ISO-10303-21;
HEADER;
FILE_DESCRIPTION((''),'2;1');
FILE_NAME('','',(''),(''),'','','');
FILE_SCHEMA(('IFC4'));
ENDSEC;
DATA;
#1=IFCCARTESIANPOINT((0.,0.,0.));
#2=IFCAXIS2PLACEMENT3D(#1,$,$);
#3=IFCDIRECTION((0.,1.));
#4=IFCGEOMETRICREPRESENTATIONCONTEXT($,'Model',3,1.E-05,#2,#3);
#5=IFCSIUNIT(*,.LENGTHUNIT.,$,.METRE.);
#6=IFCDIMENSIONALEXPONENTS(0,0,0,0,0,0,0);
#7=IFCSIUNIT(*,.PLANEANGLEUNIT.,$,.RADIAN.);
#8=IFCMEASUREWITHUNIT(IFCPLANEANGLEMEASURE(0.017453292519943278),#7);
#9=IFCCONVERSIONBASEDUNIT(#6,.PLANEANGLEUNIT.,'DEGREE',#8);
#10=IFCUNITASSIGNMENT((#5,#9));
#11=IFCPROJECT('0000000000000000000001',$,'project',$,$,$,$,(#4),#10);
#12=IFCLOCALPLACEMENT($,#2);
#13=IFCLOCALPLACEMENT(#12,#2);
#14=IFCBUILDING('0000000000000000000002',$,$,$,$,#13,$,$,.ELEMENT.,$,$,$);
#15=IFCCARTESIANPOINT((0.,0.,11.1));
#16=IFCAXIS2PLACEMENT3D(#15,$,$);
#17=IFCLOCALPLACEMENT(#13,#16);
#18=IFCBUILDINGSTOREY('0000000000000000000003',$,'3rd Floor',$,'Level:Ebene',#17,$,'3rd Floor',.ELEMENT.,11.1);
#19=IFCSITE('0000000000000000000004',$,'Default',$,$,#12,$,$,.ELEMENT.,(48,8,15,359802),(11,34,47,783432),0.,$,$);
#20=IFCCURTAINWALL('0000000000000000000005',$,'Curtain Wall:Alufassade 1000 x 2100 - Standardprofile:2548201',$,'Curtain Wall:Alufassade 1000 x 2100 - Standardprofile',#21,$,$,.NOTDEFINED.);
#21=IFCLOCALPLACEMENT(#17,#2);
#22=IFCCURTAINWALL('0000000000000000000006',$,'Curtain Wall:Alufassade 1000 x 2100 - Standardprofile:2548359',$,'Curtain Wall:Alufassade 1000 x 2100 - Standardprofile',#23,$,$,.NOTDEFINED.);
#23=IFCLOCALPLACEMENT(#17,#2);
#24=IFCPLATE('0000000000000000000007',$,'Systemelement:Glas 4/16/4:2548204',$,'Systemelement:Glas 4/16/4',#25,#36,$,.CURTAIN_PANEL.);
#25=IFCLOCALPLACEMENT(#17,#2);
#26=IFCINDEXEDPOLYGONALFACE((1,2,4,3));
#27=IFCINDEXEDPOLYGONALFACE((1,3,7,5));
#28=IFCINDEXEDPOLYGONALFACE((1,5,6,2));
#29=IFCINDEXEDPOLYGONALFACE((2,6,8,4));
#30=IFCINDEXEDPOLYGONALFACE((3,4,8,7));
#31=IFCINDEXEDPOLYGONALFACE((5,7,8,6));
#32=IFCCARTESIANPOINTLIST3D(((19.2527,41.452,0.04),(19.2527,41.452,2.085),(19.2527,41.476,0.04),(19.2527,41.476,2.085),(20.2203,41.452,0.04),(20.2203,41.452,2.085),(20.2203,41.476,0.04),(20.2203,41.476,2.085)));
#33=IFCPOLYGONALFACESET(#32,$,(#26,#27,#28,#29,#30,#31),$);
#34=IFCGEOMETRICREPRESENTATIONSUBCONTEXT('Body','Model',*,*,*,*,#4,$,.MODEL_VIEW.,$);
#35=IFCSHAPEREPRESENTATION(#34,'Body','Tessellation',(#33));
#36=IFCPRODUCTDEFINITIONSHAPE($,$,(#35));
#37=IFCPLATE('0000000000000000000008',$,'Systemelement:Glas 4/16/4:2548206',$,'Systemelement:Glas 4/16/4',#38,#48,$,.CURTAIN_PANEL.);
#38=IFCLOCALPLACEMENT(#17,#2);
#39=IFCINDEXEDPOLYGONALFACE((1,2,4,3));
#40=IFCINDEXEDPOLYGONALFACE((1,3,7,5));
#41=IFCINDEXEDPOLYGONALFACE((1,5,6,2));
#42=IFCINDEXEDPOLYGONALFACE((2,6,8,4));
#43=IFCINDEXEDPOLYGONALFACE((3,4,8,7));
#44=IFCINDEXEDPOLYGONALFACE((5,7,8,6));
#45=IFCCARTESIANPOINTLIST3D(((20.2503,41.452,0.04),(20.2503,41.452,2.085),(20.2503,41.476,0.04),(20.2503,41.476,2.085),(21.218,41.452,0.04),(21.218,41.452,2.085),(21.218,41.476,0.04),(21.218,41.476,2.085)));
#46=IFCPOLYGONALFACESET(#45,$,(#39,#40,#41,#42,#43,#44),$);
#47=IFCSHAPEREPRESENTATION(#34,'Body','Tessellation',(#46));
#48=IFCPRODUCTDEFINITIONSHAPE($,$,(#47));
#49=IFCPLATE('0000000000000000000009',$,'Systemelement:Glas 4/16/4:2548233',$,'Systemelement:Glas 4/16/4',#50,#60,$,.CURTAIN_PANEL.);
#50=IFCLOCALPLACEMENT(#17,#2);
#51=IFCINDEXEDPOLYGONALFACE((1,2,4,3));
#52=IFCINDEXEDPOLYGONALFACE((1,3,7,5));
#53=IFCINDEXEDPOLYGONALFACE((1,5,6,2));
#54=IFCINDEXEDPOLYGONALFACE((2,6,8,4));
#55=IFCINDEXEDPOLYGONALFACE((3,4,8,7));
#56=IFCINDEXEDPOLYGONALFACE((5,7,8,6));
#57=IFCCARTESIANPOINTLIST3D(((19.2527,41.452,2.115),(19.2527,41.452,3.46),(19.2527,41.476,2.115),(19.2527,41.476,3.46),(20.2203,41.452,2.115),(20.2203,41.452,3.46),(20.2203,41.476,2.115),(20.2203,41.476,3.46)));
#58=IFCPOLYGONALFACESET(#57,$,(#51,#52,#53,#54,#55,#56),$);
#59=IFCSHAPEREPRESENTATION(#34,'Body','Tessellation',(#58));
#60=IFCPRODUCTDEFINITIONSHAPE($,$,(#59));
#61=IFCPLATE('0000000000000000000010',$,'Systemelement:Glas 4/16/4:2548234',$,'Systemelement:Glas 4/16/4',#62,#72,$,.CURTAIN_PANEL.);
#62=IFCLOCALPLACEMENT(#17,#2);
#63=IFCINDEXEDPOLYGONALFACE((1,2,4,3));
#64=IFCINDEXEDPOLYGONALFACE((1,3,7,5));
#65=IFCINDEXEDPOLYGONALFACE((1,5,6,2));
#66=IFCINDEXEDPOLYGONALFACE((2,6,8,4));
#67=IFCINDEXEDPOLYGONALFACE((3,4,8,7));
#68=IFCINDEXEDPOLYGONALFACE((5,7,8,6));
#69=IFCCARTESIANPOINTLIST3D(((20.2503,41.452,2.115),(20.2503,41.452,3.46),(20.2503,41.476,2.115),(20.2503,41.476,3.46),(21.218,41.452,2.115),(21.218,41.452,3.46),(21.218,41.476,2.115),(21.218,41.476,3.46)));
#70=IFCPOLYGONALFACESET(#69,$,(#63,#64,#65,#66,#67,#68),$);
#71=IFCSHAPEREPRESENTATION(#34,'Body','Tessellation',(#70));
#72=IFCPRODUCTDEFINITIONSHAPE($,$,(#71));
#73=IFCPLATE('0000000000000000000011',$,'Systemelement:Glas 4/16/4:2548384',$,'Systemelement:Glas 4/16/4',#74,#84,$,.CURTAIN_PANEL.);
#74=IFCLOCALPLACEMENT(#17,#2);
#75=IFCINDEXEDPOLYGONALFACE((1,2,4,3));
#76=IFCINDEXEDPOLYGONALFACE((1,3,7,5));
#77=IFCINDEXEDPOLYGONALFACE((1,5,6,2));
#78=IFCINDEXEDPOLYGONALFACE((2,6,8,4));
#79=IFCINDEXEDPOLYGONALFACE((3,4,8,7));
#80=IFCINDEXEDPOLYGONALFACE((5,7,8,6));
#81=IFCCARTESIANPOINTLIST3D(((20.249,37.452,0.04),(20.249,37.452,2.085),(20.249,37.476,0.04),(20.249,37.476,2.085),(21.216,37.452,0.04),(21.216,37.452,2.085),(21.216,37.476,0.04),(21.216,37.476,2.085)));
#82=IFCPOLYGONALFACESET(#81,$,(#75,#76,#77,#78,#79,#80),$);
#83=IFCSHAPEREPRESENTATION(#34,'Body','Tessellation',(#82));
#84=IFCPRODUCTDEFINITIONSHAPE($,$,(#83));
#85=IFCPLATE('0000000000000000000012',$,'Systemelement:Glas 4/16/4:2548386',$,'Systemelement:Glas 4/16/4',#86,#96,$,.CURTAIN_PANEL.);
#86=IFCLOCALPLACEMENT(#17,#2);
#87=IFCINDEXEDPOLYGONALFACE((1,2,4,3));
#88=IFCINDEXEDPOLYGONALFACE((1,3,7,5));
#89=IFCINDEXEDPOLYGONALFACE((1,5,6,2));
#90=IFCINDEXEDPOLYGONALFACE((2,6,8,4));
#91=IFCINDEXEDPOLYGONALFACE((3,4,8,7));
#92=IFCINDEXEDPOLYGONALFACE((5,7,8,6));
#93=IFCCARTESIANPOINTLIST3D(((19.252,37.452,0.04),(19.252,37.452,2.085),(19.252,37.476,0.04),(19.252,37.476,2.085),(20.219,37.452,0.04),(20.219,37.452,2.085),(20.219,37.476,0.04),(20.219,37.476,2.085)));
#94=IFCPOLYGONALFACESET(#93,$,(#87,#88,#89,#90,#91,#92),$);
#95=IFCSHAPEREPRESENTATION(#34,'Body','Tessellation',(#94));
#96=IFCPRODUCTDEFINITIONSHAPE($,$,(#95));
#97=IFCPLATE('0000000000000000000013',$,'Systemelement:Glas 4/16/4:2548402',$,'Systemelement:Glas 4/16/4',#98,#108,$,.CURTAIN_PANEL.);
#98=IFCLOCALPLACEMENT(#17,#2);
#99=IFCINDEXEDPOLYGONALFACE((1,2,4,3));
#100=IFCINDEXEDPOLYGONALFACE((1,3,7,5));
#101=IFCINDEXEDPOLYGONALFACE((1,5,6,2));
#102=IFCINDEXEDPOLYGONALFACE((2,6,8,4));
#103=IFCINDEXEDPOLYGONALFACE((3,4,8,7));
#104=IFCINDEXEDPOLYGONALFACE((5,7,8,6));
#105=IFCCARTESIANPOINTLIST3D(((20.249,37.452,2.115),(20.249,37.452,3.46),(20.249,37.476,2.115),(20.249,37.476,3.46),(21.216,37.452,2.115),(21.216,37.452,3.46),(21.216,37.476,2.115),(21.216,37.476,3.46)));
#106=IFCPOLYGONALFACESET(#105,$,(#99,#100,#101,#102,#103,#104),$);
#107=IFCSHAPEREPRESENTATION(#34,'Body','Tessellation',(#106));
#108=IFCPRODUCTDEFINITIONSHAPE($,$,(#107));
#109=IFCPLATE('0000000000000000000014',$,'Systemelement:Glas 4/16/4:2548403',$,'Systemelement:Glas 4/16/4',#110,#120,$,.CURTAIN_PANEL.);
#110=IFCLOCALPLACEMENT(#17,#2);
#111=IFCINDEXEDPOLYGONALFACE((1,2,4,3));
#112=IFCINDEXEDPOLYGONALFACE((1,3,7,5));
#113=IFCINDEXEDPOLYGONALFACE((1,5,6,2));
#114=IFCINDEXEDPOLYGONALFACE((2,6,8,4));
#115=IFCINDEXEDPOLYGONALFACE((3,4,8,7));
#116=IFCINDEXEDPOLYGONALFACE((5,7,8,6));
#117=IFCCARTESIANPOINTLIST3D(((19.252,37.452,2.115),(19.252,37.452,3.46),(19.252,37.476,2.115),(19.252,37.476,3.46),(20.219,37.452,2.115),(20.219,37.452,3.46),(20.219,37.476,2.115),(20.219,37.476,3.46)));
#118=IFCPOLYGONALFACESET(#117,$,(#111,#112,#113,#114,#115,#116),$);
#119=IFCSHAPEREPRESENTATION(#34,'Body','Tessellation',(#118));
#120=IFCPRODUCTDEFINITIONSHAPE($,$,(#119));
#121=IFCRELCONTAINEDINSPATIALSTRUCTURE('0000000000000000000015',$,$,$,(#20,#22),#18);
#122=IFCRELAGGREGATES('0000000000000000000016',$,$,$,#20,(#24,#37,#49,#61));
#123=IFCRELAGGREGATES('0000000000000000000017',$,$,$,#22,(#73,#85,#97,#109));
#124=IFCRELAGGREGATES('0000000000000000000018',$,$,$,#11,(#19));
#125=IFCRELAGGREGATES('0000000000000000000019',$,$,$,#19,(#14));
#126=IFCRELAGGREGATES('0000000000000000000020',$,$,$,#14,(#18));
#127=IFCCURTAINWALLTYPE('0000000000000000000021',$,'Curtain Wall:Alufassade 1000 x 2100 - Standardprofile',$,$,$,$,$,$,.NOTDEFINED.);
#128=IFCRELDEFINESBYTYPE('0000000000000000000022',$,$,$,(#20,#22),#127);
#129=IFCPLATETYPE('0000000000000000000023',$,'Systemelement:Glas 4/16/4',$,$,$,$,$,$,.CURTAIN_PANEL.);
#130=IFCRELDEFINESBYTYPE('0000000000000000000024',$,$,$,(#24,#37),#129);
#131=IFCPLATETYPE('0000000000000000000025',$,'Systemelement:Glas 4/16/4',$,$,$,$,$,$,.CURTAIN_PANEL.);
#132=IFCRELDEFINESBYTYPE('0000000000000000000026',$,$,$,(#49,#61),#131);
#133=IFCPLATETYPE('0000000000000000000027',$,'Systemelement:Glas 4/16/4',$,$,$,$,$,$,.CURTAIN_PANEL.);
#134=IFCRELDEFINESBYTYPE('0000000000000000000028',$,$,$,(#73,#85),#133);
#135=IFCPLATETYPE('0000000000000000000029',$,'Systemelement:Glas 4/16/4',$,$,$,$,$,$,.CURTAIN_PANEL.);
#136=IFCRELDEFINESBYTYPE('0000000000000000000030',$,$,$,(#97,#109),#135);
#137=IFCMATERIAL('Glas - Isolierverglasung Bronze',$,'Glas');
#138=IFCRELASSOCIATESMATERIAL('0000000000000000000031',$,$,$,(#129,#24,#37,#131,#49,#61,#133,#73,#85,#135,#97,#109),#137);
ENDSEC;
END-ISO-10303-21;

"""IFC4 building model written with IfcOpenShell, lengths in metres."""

from ifc_helpers import new_model, entity, si_unit, converted_unit, direction, frame, origin, place, context, subcontext, project, spatial, indexed_curve, outline, extrude, source, transform, mapped, material, type_object, type_shapes, element, aggregate, save


model = new_model("IFC4")

# Units and contexts
model_context = context("Model", 3, precision=1e-05, world=origin(), true_north=direction((0.0, 1.0)))
body_context = subcontext(model_context, "Body", "Model", "MODEL_VIEW")
ifc_project = project(units=[si_unit("LENGTHUNIT", "METRE"), converted_unit("PLANEANGLEUNIT", "DEGREE", entity("IfcPlaneAngleMeasure", 0.017453292519943278), si_unit("PLANEANGLEUNIT", "RADIAN"), dimensions=[0, 0, 0, 0, 0, 0, 0])], contexts=[model_context])

# Site, building, storey
site_placement = place(None, origin())
site = spatial("IfcSite", under=ifc_project, at=site_placement, Name="Default", CompositionType="ELEMENT", RefLatitude=(48, 8, 15, 359802), RefLongitude=(11, 34, 47, 783432), RefElevation=0.0)
building_placement = place(site_placement, origin())
building = spatial("IfcBuilding", under=site, at=building_placement, CompositionType="ELEMENT")
storey_placement = place(building_placement, frame((0.0, 0.0, 11.1)))
storey = spatial("IfcBuildingStorey", under=building, at=storey_placement, Name="3rd Floor", ObjectType="Level:Ebene", LongName="3rd Floor", CompositionType="ELEMENT", Elevation=11.1)

# Curtain walls
curtain_wall_type = type_object("IfcCurtainWallType", Name="Curtain Wall:Alufassade 1000 x 2100 - Standardprofile", PredefinedType="NOTDEFINED")
curtain_wall_1_placement = place(storey_placement, frame((0.0, 0.0, -11.1)))
curtain_wall_1 = element("IfcCurtainWall", 1, at=curtain_wall_1_placement, inside=storey, type_object=curtain_wall_type, Name="Curtain Wall:Alufassade 1000 x 2100 - Standardprofile:2548201", ObjectType="Curtain Wall:Alufassade 1000 x 2100 - Standardprofile", PredefinedType="NOTDEFINED")
curtain_wall_2_placement = place(storey_placement, frame((0.0, 0.0, -11.1)))
curtain_wall_2 = element("IfcCurtainWall", 2, at=curtain_wall_2_placement, inside=storey, type_object=curtain_wall_type, Name="Curtain Wall:Alufassade 1000 x 2100 - Standardprofile:2548359", ObjectType="Curtain Wall:Alufassade 1000 x 2100 - Standardprofile", PredefinedType="NOTDEFINED")

# Plates
ifc_material_1 = material(Name="Glas - Isolierverglasung Bronze", Category="Glas")
plate_type_1 = type_object("IfcPlateType", Name="Systemelement:Glas 4/16/4", PredefinedType="CURTAIN_PANEL", material=ifc_material_1)
shared_shape_1 = source(origin(), body_context, "Body", "SweptSolid", [
    extrude(outline(indexed_curve([(-0.012, -0.4838), (0.012, -0.4838), (0.012, 0.4838), (-0.012, 0.4838), (-0.012, -0.4838)], self_intersect=False)), frame((0.0, 0.0, 0.0), z_axis=(0.0, 0.0, 1.0), x_axis=(0.0, 1.0, 0.0)), (0.0, 0.0, 1.0), 2.045),
])
type_shapes(plate_type_1, [shared_shape_1])
plate_1_placement = place(curtain_wall_1_placement, frame((19.7365, 41.464, 11.14)))
plate_1 = element("IfcPlate", 3, at=plate_1_placement, type_object=plate_type_1, material=ifc_material_1, Name="Systemelement:Glas 4/16/4:2548204", ObjectType="Systemelement:Glas 4/16/4", PredefinedType="CURTAIN_PANEL", context=body_context, shape_type="MappedRepresentation", body=[
    mapped(shared_shape_1, transform((0.0, 0.0, 0.0), scale=1.0)),
])
plate_2_placement = place(curtain_wall_1_placement, frame((20.7342, 41.464, 11.14)))
plate_2 = element("IfcPlate", 4, at=plate_2_placement, type_object=plate_type_1, material=ifc_material_1, Name="Systemelement:Glas 4/16/4:2548206", ObjectType="Systemelement:Glas 4/16/4", PredefinedType="CURTAIN_PANEL", context=body_context, shape_type="MappedRepresentation", body=[
    mapped(shared_shape_1, transform((0.0, 0.0, 0.0), scale=1.0)),
])
plate_type_2 = type_object("IfcPlateType", Name="Systemelement:Glas 4/16/4", PredefinedType="CURTAIN_PANEL", material=ifc_material_1)
shared_shape_2 = source(origin(), body_context, "Body", "SweptSolid", [
    extrude(outline(indexed_curve([(-0.012, -0.4838), (0.012, -0.4838), (0.012, 0.4838), (-0.012, 0.4838), (-0.012, -0.4838)], self_intersect=False)), frame((0.0, 0.0, 0.0), z_axis=(0.0, 0.0, 1.0), x_axis=(0.0, 1.0, 0.0)), (0.0, 0.0, 1.0), 1.345),
])
type_shapes(plate_type_2, [shared_shape_2])
plate_3_placement = place(curtain_wall_1_placement, frame((19.7365, 41.464, 13.215)))
plate_3 = element("IfcPlate", 5, at=plate_3_placement, type_object=plate_type_2, material=ifc_material_1, Name="Systemelement:Glas 4/16/4:2548233", ObjectType="Systemelement:Glas 4/16/4", PredefinedType="CURTAIN_PANEL", context=body_context, shape_type="MappedRepresentation", body=[
    mapped(shared_shape_2, transform((0.0, 0.0, 0.0), scale=1.0)),
])
plate_4_placement = place(curtain_wall_1_placement, frame((20.7342, 41.464, 13.215)))
plate_4 = element("IfcPlate", 6, at=plate_4_placement, type_object=plate_type_2, material=ifc_material_1, Name="Systemelement:Glas 4/16/4:2548234", ObjectType="Systemelement:Glas 4/16/4", PredefinedType="CURTAIN_PANEL", context=body_context, shape_type="MappedRepresentation", body=[
    mapped(shared_shape_2, transform((0.0, 0.0, 0.0), scale=1.0)),
])
aggregate(curtain_wall_1, [plate_1, plate_2, plate_3, plate_4])
plate_type_3 = type_object("IfcPlateType", Name="Systemelement:Glas 4/16/4", PredefinedType="CURTAIN_PANEL", material=ifc_material_1)
shared_shape_3 = source(origin(), body_context, "Body", "SweptSolid", [
    extrude(outline(indexed_curve([(-0.012, -0.4835), (0.012, -0.4835), (0.012, 0.4835), (-0.012, 0.4835), (-0.012, -0.4835)], self_intersect=False)), frame((0.0, 0.0, 0.0), z_axis=(0.0, 0.0, 1.0), x_axis=(0.0, 1.0, 0.0)), (0.0, 0.0, 1.0), 2.045),
])
type_shapes(plate_type_3, [shared_shape_3])
plate_5_placement = place(curtain_wall_2_placement, frame((20.7325, 37.464, 11.14), z_axis=(0.0, 0.0, 1.0), x_axis=(-1.0, 0.0, 0.0)))
plate_5 = element("IfcPlate", 7, at=plate_5_placement, type_object=plate_type_3, material=ifc_material_1, Name="Systemelement:Glas 4/16/4:2548384", ObjectType="Systemelement:Glas 4/16/4", PredefinedType="CURTAIN_PANEL", context=body_context, shape_type="MappedRepresentation", body=[
    mapped(shared_shape_3, transform((0.0, 0.0, 0.0), scale=1.0)),
])
plate_6_placement = place(curtain_wall_2_placement, frame((19.7355, 37.464, 11.14), z_axis=(0.0, 0.0, 1.0), x_axis=(-1.0, 0.0, 0.0)))
plate_6 = element("IfcPlate", 8, at=plate_6_placement, type_object=plate_type_3, material=ifc_material_1, Name="Systemelement:Glas 4/16/4:2548386", ObjectType="Systemelement:Glas 4/16/4", PredefinedType="CURTAIN_PANEL", context=body_context, shape_type="MappedRepresentation", body=[
    mapped(shared_shape_3, transform((0.0, 0.0, 0.0), scale=1.0)),
])
plate_type_4 = type_object("IfcPlateType", Name="Systemelement:Glas 4/16/4", PredefinedType="CURTAIN_PANEL", material=ifc_material_1)
shared_shape_4 = source(origin(), body_context, "Body", "SweptSolid", [
    extrude(outline(indexed_curve([(-0.012, -0.4835), (0.012, -0.4835), (0.012, 0.4835), (-0.012, 0.4835), (-0.012, -0.4835)], self_intersect=False)), frame((0.0, 0.0, 0.0), z_axis=(0.0, 0.0, 1.0), x_axis=(0.0, 1.0, 0.0)), (0.0, 0.0, 1.0), 1.345),
])
type_shapes(plate_type_4, [shared_shape_4])
plate_7_placement = place(curtain_wall_2_placement, frame((20.7325, 37.464, 13.215), z_axis=(0.0, 0.0, 1.0), x_axis=(-1.0, 0.0, 0.0)))
plate_7 = element("IfcPlate", 9, at=plate_7_placement, type_object=plate_type_4, material=ifc_material_1, Name="Systemelement:Glas 4/16/4:2548402", ObjectType="Systemelement:Glas 4/16/4", PredefinedType="CURTAIN_PANEL", context=body_context, shape_type="MappedRepresentation", body=[
    mapped(shared_shape_4, transform((0.0, 0.0, 0.0), scale=1.0)),
])
plate_8_placement = place(curtain_wall_2_placement, frame((19.7355, 37.464, 13.215), z_axis=(0.0, 0.0, 1.0), x_axis=(-1.0, 0.0, 0.0)))
plate_8 = element("IfcPlate", 10, at=plate_8_placement, type_object=plate_type_4, material=ifc_material_1, Name="Systemelement:Glas 4/16/4:2548403", ObjectType="Systemelement:Glas 4/16/4", PredefinedType="CURTAIN_PANEL", context=body_context, shape_type="MappedRepresentation", body=[
    mapped(shared_shape_4, transform((0.0, 0.0, 0.0), scale=1.0)),
])
aggregate(curtain_wall_2, [plate_5, plate_6, plate_7, plate_8])

save(model, "model.ifc")
